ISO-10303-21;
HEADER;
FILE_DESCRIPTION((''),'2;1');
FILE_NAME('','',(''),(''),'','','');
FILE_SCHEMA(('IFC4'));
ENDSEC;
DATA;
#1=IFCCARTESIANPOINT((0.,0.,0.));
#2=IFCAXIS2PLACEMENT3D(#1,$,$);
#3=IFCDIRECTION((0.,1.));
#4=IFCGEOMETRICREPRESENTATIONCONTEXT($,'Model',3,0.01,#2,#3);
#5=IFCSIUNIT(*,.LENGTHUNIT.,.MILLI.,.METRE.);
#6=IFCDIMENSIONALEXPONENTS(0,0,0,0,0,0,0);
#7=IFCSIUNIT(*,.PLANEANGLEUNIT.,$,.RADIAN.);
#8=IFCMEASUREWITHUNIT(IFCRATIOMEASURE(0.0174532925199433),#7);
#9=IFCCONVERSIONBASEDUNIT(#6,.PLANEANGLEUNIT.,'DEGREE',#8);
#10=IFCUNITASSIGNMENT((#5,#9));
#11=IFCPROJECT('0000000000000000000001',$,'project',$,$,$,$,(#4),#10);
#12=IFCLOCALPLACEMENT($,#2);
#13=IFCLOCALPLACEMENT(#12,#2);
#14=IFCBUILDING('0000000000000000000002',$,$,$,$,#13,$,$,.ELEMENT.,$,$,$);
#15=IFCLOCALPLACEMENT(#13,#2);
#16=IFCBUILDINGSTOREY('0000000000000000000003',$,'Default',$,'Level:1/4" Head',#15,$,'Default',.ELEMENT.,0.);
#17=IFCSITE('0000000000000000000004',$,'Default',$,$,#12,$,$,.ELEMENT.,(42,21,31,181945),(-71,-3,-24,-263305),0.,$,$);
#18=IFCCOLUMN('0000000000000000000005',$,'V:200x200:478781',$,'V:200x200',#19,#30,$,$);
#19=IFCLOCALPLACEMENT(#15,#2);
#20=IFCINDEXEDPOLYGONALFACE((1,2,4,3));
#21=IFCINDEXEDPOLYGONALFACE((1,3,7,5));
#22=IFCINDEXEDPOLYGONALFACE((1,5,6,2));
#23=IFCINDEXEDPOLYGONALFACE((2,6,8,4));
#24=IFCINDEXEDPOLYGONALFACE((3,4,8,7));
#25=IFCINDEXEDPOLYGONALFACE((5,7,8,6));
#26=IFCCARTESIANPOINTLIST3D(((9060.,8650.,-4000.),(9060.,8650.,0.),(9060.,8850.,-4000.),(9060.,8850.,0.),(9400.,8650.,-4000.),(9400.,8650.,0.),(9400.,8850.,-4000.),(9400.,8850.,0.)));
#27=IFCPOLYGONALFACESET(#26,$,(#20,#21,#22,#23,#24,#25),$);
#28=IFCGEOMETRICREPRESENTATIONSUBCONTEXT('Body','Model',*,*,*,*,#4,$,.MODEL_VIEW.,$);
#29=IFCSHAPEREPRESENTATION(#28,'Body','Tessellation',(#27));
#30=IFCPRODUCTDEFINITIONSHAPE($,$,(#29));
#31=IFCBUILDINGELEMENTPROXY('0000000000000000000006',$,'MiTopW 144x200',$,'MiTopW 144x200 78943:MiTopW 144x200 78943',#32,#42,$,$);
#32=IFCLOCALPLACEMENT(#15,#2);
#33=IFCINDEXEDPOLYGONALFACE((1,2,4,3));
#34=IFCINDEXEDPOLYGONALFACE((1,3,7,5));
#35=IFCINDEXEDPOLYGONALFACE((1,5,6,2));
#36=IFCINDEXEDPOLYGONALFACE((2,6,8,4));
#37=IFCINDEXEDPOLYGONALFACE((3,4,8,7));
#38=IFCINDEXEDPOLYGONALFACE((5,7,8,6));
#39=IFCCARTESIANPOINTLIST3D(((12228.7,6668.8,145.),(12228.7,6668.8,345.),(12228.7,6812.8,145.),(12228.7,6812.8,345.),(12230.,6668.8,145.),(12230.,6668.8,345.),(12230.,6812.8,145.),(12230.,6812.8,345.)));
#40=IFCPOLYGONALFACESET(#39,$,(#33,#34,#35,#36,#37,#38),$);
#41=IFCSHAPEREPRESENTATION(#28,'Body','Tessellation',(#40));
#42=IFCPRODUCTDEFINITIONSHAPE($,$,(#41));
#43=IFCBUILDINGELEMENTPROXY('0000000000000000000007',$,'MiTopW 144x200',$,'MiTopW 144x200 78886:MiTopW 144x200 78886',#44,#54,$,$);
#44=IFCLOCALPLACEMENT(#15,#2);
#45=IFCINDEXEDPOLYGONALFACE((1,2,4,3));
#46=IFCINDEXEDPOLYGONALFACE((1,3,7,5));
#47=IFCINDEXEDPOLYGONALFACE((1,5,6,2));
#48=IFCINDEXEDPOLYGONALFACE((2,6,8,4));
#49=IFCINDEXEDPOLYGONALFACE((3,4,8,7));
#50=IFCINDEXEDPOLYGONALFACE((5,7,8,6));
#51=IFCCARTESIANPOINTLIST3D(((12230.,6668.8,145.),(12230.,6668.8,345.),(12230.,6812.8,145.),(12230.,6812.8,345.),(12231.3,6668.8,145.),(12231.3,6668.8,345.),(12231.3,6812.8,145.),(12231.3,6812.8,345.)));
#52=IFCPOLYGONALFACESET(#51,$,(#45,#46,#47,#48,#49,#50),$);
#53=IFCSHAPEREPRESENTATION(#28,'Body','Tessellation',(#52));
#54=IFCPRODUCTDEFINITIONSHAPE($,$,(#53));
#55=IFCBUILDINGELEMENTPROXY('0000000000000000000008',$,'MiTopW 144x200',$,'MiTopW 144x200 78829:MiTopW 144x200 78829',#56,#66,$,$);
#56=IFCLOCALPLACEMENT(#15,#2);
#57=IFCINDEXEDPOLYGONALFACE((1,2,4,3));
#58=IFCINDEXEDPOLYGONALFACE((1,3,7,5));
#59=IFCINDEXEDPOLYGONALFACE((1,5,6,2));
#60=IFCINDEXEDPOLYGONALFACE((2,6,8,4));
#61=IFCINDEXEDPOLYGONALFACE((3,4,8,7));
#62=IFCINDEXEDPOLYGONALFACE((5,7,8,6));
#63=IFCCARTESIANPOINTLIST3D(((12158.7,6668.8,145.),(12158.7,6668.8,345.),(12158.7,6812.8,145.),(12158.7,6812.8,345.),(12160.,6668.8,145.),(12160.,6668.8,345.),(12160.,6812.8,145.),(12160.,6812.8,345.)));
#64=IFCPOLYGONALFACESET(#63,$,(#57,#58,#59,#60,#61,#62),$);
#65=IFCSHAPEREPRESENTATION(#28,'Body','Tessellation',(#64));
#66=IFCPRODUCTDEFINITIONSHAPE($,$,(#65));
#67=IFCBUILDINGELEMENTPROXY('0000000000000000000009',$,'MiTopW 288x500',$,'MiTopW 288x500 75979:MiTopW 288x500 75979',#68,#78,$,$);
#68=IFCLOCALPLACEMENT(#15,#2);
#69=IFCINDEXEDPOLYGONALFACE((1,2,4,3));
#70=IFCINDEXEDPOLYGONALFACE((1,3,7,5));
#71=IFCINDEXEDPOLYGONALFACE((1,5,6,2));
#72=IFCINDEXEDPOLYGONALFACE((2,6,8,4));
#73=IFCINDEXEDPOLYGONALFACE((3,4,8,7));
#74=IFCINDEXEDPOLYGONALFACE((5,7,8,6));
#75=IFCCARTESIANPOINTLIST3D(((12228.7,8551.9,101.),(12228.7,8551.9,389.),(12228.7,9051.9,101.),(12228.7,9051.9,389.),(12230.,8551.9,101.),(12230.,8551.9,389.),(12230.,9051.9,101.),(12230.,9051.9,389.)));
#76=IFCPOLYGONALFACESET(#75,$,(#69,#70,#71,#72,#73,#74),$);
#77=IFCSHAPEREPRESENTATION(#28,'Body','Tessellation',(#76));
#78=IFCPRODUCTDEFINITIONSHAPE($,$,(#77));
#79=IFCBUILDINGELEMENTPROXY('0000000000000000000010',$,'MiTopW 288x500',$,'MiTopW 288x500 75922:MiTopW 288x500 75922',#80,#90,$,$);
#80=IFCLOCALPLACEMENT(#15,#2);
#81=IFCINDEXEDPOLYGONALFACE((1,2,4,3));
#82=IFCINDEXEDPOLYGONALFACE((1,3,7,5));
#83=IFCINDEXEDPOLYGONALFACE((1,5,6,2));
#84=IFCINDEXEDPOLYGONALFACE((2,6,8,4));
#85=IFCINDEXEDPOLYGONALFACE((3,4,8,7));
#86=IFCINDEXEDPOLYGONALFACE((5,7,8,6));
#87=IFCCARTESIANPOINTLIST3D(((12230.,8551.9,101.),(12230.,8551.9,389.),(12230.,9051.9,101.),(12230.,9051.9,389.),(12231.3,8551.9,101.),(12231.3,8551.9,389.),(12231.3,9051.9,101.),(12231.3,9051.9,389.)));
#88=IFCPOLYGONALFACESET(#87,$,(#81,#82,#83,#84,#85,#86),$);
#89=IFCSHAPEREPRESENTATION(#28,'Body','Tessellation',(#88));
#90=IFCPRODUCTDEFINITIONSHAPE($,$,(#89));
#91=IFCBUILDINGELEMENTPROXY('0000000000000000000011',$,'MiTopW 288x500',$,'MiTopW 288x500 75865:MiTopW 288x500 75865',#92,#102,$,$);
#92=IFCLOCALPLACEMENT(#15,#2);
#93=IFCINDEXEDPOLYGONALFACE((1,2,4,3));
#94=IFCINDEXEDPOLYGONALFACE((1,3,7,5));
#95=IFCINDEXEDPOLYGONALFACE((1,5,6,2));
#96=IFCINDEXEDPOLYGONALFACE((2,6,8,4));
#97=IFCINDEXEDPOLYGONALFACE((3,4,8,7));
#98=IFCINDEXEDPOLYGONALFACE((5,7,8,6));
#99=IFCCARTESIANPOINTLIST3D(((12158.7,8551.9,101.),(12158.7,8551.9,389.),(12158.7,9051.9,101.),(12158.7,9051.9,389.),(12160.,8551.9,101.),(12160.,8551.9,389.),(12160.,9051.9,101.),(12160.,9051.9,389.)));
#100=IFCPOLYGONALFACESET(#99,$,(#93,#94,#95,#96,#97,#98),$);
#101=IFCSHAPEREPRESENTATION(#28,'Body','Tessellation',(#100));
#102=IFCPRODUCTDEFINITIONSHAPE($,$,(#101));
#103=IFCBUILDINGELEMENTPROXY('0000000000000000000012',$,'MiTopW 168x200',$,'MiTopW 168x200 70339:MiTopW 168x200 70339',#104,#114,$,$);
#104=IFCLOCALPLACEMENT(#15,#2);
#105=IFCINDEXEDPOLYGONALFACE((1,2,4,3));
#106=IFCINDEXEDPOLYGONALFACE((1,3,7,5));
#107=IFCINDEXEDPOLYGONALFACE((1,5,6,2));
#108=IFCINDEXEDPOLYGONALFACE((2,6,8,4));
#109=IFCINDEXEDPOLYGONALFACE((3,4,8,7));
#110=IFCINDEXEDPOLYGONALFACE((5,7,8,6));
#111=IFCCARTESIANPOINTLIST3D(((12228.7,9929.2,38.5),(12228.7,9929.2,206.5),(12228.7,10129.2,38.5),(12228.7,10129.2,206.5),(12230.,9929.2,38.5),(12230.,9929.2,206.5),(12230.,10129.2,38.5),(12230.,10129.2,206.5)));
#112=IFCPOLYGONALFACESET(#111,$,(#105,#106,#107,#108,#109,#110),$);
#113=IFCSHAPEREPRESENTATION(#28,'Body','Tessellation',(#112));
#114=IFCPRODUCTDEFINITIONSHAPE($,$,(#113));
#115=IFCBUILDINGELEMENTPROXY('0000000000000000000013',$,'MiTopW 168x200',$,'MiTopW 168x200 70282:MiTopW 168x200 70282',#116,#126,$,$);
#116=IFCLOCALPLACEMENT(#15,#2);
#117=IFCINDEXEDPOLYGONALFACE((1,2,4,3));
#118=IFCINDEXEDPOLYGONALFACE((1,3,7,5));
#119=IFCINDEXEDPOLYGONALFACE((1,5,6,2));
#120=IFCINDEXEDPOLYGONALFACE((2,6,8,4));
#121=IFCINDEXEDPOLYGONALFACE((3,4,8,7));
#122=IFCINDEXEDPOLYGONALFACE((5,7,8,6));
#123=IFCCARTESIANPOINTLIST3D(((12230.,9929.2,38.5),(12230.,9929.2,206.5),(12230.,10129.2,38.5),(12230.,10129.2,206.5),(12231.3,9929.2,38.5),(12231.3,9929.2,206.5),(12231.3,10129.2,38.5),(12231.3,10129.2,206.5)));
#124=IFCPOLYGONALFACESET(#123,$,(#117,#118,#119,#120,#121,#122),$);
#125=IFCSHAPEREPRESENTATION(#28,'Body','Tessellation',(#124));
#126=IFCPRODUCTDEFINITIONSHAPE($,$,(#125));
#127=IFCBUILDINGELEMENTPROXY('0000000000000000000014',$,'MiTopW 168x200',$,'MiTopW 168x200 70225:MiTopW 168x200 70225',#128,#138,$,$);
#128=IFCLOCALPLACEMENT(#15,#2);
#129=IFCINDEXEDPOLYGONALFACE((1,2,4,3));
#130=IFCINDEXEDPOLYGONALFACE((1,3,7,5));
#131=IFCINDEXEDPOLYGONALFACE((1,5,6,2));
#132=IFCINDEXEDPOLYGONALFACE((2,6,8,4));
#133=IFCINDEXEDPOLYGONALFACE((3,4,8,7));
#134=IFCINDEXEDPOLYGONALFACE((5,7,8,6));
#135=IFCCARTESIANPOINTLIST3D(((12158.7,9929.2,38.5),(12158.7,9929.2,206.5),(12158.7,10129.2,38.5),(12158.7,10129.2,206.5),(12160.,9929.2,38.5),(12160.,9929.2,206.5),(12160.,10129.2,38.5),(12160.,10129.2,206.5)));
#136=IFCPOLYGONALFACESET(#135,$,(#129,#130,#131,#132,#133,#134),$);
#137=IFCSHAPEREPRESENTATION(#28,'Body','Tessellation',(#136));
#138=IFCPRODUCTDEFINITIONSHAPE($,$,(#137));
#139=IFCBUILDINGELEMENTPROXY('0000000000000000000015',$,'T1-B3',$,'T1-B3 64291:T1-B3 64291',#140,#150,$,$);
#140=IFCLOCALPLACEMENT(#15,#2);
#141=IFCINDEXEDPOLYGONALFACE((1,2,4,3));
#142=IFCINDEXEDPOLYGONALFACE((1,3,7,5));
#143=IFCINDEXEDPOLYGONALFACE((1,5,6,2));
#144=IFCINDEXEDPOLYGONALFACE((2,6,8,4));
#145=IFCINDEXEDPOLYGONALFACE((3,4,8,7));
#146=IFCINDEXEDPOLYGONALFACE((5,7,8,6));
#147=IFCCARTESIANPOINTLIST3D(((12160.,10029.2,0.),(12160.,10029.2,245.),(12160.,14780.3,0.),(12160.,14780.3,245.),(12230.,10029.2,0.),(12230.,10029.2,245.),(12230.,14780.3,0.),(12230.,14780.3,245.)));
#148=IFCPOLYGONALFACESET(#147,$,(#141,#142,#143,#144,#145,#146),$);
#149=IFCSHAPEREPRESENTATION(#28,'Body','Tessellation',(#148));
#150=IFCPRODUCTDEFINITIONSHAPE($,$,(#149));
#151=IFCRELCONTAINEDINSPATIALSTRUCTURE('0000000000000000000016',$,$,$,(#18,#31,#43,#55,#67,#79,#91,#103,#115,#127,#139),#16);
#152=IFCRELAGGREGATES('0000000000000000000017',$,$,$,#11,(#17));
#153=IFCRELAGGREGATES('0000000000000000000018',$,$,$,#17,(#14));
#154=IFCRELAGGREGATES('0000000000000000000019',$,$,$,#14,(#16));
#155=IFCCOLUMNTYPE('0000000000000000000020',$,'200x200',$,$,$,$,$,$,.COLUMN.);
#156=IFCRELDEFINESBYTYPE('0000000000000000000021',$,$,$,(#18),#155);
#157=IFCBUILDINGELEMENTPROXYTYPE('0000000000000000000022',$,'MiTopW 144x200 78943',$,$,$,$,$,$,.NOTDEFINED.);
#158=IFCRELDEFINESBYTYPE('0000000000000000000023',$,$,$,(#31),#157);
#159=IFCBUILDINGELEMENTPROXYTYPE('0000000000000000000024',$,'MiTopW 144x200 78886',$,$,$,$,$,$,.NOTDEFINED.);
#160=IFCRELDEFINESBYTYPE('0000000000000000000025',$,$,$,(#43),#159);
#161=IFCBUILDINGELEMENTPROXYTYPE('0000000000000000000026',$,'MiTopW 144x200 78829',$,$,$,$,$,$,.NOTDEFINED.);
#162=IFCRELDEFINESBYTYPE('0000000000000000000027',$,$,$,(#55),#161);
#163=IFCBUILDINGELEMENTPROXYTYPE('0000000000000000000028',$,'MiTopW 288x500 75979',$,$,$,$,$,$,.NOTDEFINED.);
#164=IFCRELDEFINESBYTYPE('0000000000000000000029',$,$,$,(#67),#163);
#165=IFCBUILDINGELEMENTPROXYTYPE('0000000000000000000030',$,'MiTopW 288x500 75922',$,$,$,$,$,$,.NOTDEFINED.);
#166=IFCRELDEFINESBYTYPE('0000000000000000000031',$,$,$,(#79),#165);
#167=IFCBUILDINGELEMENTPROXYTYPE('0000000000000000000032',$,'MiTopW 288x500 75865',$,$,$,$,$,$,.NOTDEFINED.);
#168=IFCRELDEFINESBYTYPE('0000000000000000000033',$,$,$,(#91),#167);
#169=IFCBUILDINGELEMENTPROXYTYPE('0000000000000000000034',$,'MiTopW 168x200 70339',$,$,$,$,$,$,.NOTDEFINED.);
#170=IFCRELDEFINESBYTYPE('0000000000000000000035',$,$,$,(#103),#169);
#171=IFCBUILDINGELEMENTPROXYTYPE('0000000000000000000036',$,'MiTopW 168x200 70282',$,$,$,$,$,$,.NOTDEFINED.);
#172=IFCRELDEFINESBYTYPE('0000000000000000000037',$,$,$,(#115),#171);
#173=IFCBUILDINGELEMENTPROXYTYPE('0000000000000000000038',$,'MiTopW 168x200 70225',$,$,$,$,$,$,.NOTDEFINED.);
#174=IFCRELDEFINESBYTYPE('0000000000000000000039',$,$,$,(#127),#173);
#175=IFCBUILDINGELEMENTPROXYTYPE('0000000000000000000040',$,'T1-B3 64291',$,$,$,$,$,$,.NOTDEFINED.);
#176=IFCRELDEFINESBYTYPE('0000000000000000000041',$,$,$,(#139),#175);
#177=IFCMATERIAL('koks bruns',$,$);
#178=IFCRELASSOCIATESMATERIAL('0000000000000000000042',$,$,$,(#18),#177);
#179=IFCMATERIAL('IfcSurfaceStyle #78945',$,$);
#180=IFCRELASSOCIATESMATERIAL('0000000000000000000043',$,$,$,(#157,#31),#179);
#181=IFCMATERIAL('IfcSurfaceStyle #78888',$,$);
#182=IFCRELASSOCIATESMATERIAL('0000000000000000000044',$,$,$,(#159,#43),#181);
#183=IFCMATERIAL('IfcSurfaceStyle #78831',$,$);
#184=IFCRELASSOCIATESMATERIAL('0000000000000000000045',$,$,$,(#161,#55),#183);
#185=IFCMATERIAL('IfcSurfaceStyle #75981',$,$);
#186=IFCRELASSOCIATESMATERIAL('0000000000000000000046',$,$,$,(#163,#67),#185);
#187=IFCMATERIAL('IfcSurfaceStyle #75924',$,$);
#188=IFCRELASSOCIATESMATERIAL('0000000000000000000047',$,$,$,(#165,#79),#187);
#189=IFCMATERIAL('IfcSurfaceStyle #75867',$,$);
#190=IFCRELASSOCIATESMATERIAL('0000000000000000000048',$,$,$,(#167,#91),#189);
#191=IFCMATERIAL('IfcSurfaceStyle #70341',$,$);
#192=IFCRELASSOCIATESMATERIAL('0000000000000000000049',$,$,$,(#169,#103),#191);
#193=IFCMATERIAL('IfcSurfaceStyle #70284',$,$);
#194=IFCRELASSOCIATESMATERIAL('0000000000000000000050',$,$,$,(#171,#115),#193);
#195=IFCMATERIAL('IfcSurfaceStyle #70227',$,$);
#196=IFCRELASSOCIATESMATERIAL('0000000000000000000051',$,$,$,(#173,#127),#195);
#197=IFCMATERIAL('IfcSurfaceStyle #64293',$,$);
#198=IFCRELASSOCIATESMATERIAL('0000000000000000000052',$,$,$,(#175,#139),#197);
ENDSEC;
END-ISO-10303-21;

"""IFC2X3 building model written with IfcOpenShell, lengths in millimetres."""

from ifc_helpers import new_model, entity, si_unit, converted_unit, direction, frame, frame_2d, origin, origin_2d_with_axis, place, context, subcontext, project, spatial, rectangle, extrude, source, transform, mapped, material, type_object, type_shapes, element, save


model = new_model("IFC2X3")

# Units and contexts
model_context = context("Model", 3, precision=0.01, world=origin(), true_north=direction((0.0, 1.0)))
body_context = subcontext(model_context, "Body", "Model", "MODEL_VIEW")
ifc_project = project(units=[si_unit("LENGTHUNIT", "METRE", prefix="MILLI"), converted_unit("PLANEANGLEUNIT", "DEGREE", entity("IfcRatioMeasure", 0.0174532925199433), si_unit("PLANEANGLEUNIT", "RADIAN"), dimensions=[0, 0, 0, 0, 0, 0, 0])], contexts=[model_context])

# Site, building, storey
site_placement = place(None, origin())
site = spatial("IfcSite", under=ifc_project, at=site_placement, Name="Default", CompositionType="ELEMENT", RefLatitude=(42, 21, 31, 181945), RefLongitude=(-71, -3, -24, -263305), RefElevation=0.0)
building_placement = place(site_placement, origin())
building = spatial("IfcBuilding", under=site, at=building_placement, CompositionType="ELEMENT")
storey_placement = place(building_placement, origin())
storey = spatial("IfcBuildingStorey", under=building, at=storey_placement, Name="Default", ObjectType="Level:1/4\" Head", LongName="Default", CompositionType="ELEMENT", Elevation=0.0)

# Column
ifc_material_1 = material(Name="koks bruns")
column_type = type_object("IfcColumnType", Name="200x200", PredefinedType="COLUMN")
shared_shape_1 = source(origin(), body_context, "Body", "SweptSolid", [
    extrude(rectangle(XDim=340.0, YDim=200.0, at=origin_2d_with_axis()), frame((100.0, 280.0, -4000.0), z_axis=(0.0, 0.0, 1.0), x_axis=(0.0, -1.0, 0.0)), (0.0, 0.0, 1.0), 4000.0),
])
type_shapes(column_type, [shared_shape_1])
column_placement = place(storey_placement, frame((9510.0, 8650.0, 0.0), z_axis=(0.0, 0.0, 1.0), x_axis=(0.0, 1.0, 0.0)))
element("IfcColumn", 1, at=column_placement, inside=storey, type_object=column_type, material=ifc_material_1, Name="V:200x200:478781", ObjectType="V:200x200", context=body_context, shape_type="MappedRepresentation", body=[
    mapped(shared_shape_1, transform((0.0, 0.0, 0.0), scale=1.0)),
])

# Building element proxies
ifc_material_2 = material(Name="IfcSurfaceStyle #78945")
building_element_proxy_type_1 = type_object("IfcBuildingElementProxyType", Name="MiTopW 144x200 78943", PredefinedType="NOTDEFINED", material=ifc_material_2)
shared_shape_2 = source(origin(), body_context, "Body", "SweptSolid", [
    extrude(rectangle(XDim=200.0, YDim=144.0, at=frame_2d((0.0, 0.0), x_axis=(1.0, 0.0))), frame((100.0, 72.0, 0.0), z_axis=(0.0, 0.0, 1.0), x_axis=(-1.0, 0.0, 0.0)), (0.0, 0.0, 1.0), 1.3),
])
type_shapes(building_element_proxy_type_1, [shared_shape_2])
proxy_1_placement = place(building_placement, frame((12230.0, 6668.8, 145.0), z_axis=(-1.0, 0.0, 0.0), x_axis=(0.0, 0.0, 1.0)))
element("IfcBuildingElementProxy", 2, at=proxy_1_placement, inside=storey, type_object=building_element_proxy_type_1, material=ifc_material_2, Name="MiTopW 144x200", ObjectType="MiTopW 144x200 78943:MiTopW 144x200 78943", context=body_context, shape_type="MappedRepresentation", body=[
    mapped(shared_shape_2, transform((0.0, 0.0, 0.0), scale=1.0)),
])
ifc_material_3 = material(Name="IfcSurfaceStyle #78888")
building_element_proxy_type_2 = type_object("IfcBuildingElementProxyType", Name="MiTopW 144x200 78886", PredefinedType="NOTDEFINED", material=ifc_material_3)
shared_shape_3 = source(origin(), body_context, "Body", "SweptSolid", [
    extrude(rectangle(XDim=200.0, YDim=144.0, at=frame_2d((0.0, 0.0), x_axis=(1.0, 0.0))), frame((100.0, 72.0, 0.0), z_axis=(0.0, 0.0, 1.0), x_axis=(-1.0, 0.0, 0.0)), (0.0, 0.0, 1.0), 1.3),
])
type_shapes(building_element_proxy_type_2, [shared_shape_3])
proxy_2_placement = place(building_placement, frame((12231.3, 6668.8, 145.0), z_axis=(-1.0, 0.0, 0.0), x_axis=(0.0, 0.0, 1.0)))
element("IfcBuildingElementProxy", 3, at=proxy_2_placement, inside=storey, type_object=building_element_proxy_type_2, material=ifc_material_3, Name="MiTopW 144x200", ObjectType="MiTopW 144x200 78886:MiTopW 144x200 78886", context=body_context, shape_type="MappedRepresentation", body=[
    mapped(shared_shape_3, transform((0.0, 0.0, 0.0), scale=1.0)),
])
ifc_material_4 = material(Name="IfcSurfaceStyle #78831")
building_element_proxy_type_3 = type_object("IfcBuildingElementProxyType", Name="MiTopW 144x200 78829", PredefinedType="NOTDEFINED", material=ifc_material_4)
shared_shape_4 = source(origin(), body_context, "Body", "SweptSolid", [
    extrude(rectangle(XDim=200.0, YDim=144.0, at=frame_2d((0.0, 0.0), x_axis=(1.0, 0.0))), frame((100.0, 72.0, 0.0), z_axis=(0.0, 0.0, 1.0), x_axis=(-1.0, 0.0, 0.0)), (0.0, 0.0, 1.0), 1.3),
])
type_shapes(building_element_proxy_type_3, [shared_shape_4])
proxy_3_placement = place(building_placement, frame((12160.0, 6668.8, 145.0), z_axis=(-1.0, 0.0, 0.0), x_axis=(0.0, 0.0, 1.0)))
element("IfcBuildingElementProxy", 4, at=proxy_3_placement, inside=storey, type_object=building_element_proxy_type_3, material=ifc_material_4, Name="MiTopW 144x200", ObjectType="MiTopW 144x200 78829:MiTopW 144x200 78829", context=body_context, shape_type="MappedRepresentation", body=[
    mapped(shared_shape_4, transform((0.0, 0.0, 0.0), scale=1.0)),
])
ifc_material_5 = material(Name="IfcSurfaceStyle #75981")
building_element_proxy_type_4 = type_object("IfcBuildingElementProxyType", Name="MiTopW 288x500 75979", PredefinedType="NOTDEFINED", material=ifc_material_5)
shared_shape_5 = source(origin(), body_context, "Body", "SweptSolid", [
    extrude(rectangle(XDim=500.0, YDim=288.0, at=frame_2d((0.0, 0.0), x_axis=(1.0, 0.0))), frame((250.0, 144.0, 0.0), z_axis=(0.0, 0.0, 1.0), x_axis=(-1.0, 0.0, 0.0)), (0.0, 0.0, 1.0), 1.3),
])
type_shapes(building_element_proxy_type_4, [shared_shape_5])
proxy_4_placement = place(building_placement, frame((12230.0, 8551.9, 389.0), z_axis=(-1.0, 0.0, 0.0), x_axis=(0.0, 1.0, 0.0)))
element("IfcBuildingElementProxy", 5, at=proxy_4_placement, inside=storey, type_object=building_element_proxy_type_4, material=ifc_material_5, Name="MiTopW 288x500", ObjectType="MiTopW 288x500 75979:MiTopW 288x500 75979", context=body_context, shape_type="MappedRepresentation", body=[
    mapped(shared_shape_5, transform((0.0, 0.0, 0.0), scale=1.0)),
])
ifc_material_6 = material(Name="IfcSurfaceStyle #75924")
building_element_proxy_type_5 = type_object("IfcBuildingElementProxyType", Name="MiTopW 288x500 75922", PredefinedType="NOTDEFINED", material=ifc_material_6)
shared_shape_6 = source(origin(), body_context, "Body", "SweptSolid", [
    extrude(rectangle(XDim=500.0, YDim=288.0, at=frame_2d((0.0, 0.0), x_axis=(1.0, 0.0))), frame((250.0, 144.0, 0.0), z_axis=(0.0, 0.0, 1.0), x_axis=(-1.0, 0.0, 0.0)), (0.0, 0.0, 1.0), 1.3),
])
type_shapes(building_element_proxy_type_5, [shared_shape_6])
proxy_5_placement = place(building_placement, frame((12231.3, 8551.9, 389.0), z_axis=(-1.0, 0.0, 0.0), x_axis=(0.0, 1.0, 0.0)))
element("IfcBuildingElementProxy", 6, at=proxy_5_placement, inside=storey, type_object=building_element_proxy_type_5, material=ifc_material_6, Name="MiTopW 288x500", ObjectType="MiTopW 288x500 75922:MiTopW 288x500 75922", context=body_context, shape_type="MappedRepresentation", body=[
    mapped(shared_shape_6, transform((0.0, 0.0, 0.0), scale=1.0)),
])
ifc_material_7 = material(Name="IfcSurfaceStyle #75867")
building_element_proxy_type_6 = type_object("IfcBuildingElementProxyType", Name="MiTopW 288x500 75865", PredefinedType="NOTDEFINED", material=ifc_material_7)
shared_shape_7 = source(origin(), body_context, "Body", "SweptSolid", [
    extrude(rectangle(XDim=500.0, YDim=288.0, at=frame_2d((0.0, 0.0), x_axis=(1.0, 0.0))), frame((250.0, 144.0, 0.0), z_axis=(0.0, 0.0, 1.0), x_axis=(-1.0, 0.0, 0.0)), (0.0, 0.0, 1.0), 1.3),
])
type_shapes(building_element_proxy_type_6, [shared_shape_7])
proxy_6_placement = place(building_placement, frame((12160.0, 8551.9, 389.0), z_axis=(-1.0, 0.0, 0.0), x_axis=(0.0, 1.0, 0.0)))
element("IfcBuildingElementProxy", 7, at=proxy_6_placement, inside=storey, type_object=building_element_proxy_type_6, material=ifc_material_7, Name="MiTopW 288x500", ObjectType="MiTopW 288x500 75865:MiTopW 288x500 75865", context=body_context, shape_type="MappedRepresentation", body=[
    mapped(shared_shape_7, transform((0.0, 0.0, 0.0), scale=1.0)),
])
ifc_material_8 = material(Name="IfcSurfaceStyle #70341")
building_element_proxy_type_7 = type_object("IfcBuildingElementProxyType", Name="MiTopW 168x200 70339", PredefinedType="NOTDEFINED", material=ifc_material_8)
shared_shape_8 = source(origin(), body_context, "Body", "SweptSolid", [
    extrude(rectangle(XDim=200.0, YDim=168.0, at=origin_2d_with_axis()), frame((100.0, 84.0, 0.0), z_axis=(0.0, 0.0, 1.0), x_axis=(-1.0, 0.0, 0.0)), (0.0, 0.0, 1.0), 1.3),
])
type_shapes(building_element_proxy_type_7, [shared_shape_8])
proxy_7_placement = place(building_placement, frame((12230.0, 9929.2, 206.5), z_axis=(-1.0, 0.0, 0.0), x_axis=(0.0, 1.0, 0.0)))
element("IfcBuildingElementProxy", 8, at=proxy_7_placement, inside=storey, type_object=building_element_proxy_type_7, material=ifc_material_8, Name="MiTopW 168x200", ObjectType="MiTopW 168x200 70339:MiTopW 168x200 70339", context=body_context, shape_type="MappedRepresentation", body=[
    mapped(shared_shape_8, transform((0.0, 0.0, 0.0), scale=1.0)),
])
ifc_material_9 = material(Name="IfcSurfaceStyle #70284")
building_element_proxy_type_8 = type_object("IfcBuildingElementProxyType", Name="MiTopW 168x200 70282", PredefinedType="NOTDEFINED", material=ifc_material_9)
shared_shape_9 = source(origin(), body_context, "Body", "SweptSolid", [
    extrude(rectangle(XDim=200.0, YDim=168.0, at=origin_2d_with_axis()), frame((100.0, 84.0, 0.0), z_axis=(0.0, 0.0, 1.0), x_axis=(-1.0, 0.0, 0.0)), (0.0, 0.0, 1.0), 1.3),
])
type_shapes(building_element_proxy_type_8, [shared_shape_9])
proxy_8_placement = place(building_placement, frame((12231.3, 9929.2, 206.5), z_axis=(-1.0, 0.0, 0.0), x_axis=(0.0, 1.0, 0.0)))
element("IfcBuildingElementProxy", 9, at=proxy_8_placement, inside=storey, type_object=building_element_proxy_type_8, material=ifc_material_9, Name="MiTopW 168x200", ObjectType="MiTopW 168x200 70282:MiTopW 168x200 70282", context=body_context, shape_type="MappedRepresentation", body=[
    mapped(shared_shape_9, transform((0.0, 0.0, 0.0), scale=1.0)),
])
ifc_material_10 = material(Name="IfcSurfaceStyle #70227")
building_element_proxy_type_9 = type_object("IfcBuildingElementProxyType", Name="MiTopW 168x200 70225", PredefinedType="NOTDEFINED", material=ifc_material_10)
shared_shape_10 = source(origin(), body_context, "Body", "SweptSolid", [
    extrude(rectangle(XDim=200.0, YDim=168.0, at=origin_2d_with_axis()), frame((100.0, 84.0, 0.0), z_axis=(0.0, 0.0, 1.0), x_axis=(-1.0, 0.0, 0.0)), (0.0, 0.0, 1.0), 1.3),
])
type_shapes(building_element_proxy_type_9, [shared_shape_10])
proxy_9_placement = place(building_placement, frame((12160.0, 9929.2, 206.5), z_axis=(-1.0, 0.0, 0.0), x_axis=(0.0, 1.0, 0.0)))
element("IfcBuildingElementProxy", 10, at=proxy_9_placement, inside=storey, type_object=building_element_proxy_type_9, material=ifc_material_10, Name="MiTopW 168x200", ObjectType="MiTopW 168x200 70225:MiTopW 168x200 70225", context=body_context, shape_type="MappedRepresentation", body=[
    mapped(shared_shape_10, transform((0.0, 0.0, 0.0), scale=1.0)),
])
ifc_material_11 = material(Name="IfcSurfaceStyle #64293")
building_element_proxy_type_10 = type_object("IfcBuildingElementProxyType", Name="T1-B3 64291", PredefinedType="NOTDEFINED", material=ifc_material_11)
shared_shape_11 = source(origin(), body_context, "Body", "SweptSolid", [
    extrude(rectangle(XDim=4751.0, YDim=245.0, at=origin_2d_with_axis()), frame((2375.5, 122.5, 0.0), z_axis=(0.0, 0.0, 1.0), x_axis=(-1.0, 0.0, 0.0)), (0.0, 0.0, 1.0), 70.0),
])
type_shapes(building_element_proxy_type_10, [shared_shape_11])
proxy_10_placement = place(building_placement, frame((12230.0, 10029.2, 245.0), z_axis=(-1.0, 0.0, 0.0), x_axis=(0.0, 1.0, 0.0)))
element("IfcBuildingElementProxy", 11, at=proxy_10_placement, inside=storey, type_object=building_element_proxy_type_10, material=ifc_material_11, Name="T1-B3", ObjectType="T1-B3 64291:T1-B3 64291", context=body_context, shape_type="MappedRepresentation", body=[
    mapped(shared_shape_11, transform((0.0, 0.0, 0.0), scale=1.0)),
])

save(model, "model.ifc")
